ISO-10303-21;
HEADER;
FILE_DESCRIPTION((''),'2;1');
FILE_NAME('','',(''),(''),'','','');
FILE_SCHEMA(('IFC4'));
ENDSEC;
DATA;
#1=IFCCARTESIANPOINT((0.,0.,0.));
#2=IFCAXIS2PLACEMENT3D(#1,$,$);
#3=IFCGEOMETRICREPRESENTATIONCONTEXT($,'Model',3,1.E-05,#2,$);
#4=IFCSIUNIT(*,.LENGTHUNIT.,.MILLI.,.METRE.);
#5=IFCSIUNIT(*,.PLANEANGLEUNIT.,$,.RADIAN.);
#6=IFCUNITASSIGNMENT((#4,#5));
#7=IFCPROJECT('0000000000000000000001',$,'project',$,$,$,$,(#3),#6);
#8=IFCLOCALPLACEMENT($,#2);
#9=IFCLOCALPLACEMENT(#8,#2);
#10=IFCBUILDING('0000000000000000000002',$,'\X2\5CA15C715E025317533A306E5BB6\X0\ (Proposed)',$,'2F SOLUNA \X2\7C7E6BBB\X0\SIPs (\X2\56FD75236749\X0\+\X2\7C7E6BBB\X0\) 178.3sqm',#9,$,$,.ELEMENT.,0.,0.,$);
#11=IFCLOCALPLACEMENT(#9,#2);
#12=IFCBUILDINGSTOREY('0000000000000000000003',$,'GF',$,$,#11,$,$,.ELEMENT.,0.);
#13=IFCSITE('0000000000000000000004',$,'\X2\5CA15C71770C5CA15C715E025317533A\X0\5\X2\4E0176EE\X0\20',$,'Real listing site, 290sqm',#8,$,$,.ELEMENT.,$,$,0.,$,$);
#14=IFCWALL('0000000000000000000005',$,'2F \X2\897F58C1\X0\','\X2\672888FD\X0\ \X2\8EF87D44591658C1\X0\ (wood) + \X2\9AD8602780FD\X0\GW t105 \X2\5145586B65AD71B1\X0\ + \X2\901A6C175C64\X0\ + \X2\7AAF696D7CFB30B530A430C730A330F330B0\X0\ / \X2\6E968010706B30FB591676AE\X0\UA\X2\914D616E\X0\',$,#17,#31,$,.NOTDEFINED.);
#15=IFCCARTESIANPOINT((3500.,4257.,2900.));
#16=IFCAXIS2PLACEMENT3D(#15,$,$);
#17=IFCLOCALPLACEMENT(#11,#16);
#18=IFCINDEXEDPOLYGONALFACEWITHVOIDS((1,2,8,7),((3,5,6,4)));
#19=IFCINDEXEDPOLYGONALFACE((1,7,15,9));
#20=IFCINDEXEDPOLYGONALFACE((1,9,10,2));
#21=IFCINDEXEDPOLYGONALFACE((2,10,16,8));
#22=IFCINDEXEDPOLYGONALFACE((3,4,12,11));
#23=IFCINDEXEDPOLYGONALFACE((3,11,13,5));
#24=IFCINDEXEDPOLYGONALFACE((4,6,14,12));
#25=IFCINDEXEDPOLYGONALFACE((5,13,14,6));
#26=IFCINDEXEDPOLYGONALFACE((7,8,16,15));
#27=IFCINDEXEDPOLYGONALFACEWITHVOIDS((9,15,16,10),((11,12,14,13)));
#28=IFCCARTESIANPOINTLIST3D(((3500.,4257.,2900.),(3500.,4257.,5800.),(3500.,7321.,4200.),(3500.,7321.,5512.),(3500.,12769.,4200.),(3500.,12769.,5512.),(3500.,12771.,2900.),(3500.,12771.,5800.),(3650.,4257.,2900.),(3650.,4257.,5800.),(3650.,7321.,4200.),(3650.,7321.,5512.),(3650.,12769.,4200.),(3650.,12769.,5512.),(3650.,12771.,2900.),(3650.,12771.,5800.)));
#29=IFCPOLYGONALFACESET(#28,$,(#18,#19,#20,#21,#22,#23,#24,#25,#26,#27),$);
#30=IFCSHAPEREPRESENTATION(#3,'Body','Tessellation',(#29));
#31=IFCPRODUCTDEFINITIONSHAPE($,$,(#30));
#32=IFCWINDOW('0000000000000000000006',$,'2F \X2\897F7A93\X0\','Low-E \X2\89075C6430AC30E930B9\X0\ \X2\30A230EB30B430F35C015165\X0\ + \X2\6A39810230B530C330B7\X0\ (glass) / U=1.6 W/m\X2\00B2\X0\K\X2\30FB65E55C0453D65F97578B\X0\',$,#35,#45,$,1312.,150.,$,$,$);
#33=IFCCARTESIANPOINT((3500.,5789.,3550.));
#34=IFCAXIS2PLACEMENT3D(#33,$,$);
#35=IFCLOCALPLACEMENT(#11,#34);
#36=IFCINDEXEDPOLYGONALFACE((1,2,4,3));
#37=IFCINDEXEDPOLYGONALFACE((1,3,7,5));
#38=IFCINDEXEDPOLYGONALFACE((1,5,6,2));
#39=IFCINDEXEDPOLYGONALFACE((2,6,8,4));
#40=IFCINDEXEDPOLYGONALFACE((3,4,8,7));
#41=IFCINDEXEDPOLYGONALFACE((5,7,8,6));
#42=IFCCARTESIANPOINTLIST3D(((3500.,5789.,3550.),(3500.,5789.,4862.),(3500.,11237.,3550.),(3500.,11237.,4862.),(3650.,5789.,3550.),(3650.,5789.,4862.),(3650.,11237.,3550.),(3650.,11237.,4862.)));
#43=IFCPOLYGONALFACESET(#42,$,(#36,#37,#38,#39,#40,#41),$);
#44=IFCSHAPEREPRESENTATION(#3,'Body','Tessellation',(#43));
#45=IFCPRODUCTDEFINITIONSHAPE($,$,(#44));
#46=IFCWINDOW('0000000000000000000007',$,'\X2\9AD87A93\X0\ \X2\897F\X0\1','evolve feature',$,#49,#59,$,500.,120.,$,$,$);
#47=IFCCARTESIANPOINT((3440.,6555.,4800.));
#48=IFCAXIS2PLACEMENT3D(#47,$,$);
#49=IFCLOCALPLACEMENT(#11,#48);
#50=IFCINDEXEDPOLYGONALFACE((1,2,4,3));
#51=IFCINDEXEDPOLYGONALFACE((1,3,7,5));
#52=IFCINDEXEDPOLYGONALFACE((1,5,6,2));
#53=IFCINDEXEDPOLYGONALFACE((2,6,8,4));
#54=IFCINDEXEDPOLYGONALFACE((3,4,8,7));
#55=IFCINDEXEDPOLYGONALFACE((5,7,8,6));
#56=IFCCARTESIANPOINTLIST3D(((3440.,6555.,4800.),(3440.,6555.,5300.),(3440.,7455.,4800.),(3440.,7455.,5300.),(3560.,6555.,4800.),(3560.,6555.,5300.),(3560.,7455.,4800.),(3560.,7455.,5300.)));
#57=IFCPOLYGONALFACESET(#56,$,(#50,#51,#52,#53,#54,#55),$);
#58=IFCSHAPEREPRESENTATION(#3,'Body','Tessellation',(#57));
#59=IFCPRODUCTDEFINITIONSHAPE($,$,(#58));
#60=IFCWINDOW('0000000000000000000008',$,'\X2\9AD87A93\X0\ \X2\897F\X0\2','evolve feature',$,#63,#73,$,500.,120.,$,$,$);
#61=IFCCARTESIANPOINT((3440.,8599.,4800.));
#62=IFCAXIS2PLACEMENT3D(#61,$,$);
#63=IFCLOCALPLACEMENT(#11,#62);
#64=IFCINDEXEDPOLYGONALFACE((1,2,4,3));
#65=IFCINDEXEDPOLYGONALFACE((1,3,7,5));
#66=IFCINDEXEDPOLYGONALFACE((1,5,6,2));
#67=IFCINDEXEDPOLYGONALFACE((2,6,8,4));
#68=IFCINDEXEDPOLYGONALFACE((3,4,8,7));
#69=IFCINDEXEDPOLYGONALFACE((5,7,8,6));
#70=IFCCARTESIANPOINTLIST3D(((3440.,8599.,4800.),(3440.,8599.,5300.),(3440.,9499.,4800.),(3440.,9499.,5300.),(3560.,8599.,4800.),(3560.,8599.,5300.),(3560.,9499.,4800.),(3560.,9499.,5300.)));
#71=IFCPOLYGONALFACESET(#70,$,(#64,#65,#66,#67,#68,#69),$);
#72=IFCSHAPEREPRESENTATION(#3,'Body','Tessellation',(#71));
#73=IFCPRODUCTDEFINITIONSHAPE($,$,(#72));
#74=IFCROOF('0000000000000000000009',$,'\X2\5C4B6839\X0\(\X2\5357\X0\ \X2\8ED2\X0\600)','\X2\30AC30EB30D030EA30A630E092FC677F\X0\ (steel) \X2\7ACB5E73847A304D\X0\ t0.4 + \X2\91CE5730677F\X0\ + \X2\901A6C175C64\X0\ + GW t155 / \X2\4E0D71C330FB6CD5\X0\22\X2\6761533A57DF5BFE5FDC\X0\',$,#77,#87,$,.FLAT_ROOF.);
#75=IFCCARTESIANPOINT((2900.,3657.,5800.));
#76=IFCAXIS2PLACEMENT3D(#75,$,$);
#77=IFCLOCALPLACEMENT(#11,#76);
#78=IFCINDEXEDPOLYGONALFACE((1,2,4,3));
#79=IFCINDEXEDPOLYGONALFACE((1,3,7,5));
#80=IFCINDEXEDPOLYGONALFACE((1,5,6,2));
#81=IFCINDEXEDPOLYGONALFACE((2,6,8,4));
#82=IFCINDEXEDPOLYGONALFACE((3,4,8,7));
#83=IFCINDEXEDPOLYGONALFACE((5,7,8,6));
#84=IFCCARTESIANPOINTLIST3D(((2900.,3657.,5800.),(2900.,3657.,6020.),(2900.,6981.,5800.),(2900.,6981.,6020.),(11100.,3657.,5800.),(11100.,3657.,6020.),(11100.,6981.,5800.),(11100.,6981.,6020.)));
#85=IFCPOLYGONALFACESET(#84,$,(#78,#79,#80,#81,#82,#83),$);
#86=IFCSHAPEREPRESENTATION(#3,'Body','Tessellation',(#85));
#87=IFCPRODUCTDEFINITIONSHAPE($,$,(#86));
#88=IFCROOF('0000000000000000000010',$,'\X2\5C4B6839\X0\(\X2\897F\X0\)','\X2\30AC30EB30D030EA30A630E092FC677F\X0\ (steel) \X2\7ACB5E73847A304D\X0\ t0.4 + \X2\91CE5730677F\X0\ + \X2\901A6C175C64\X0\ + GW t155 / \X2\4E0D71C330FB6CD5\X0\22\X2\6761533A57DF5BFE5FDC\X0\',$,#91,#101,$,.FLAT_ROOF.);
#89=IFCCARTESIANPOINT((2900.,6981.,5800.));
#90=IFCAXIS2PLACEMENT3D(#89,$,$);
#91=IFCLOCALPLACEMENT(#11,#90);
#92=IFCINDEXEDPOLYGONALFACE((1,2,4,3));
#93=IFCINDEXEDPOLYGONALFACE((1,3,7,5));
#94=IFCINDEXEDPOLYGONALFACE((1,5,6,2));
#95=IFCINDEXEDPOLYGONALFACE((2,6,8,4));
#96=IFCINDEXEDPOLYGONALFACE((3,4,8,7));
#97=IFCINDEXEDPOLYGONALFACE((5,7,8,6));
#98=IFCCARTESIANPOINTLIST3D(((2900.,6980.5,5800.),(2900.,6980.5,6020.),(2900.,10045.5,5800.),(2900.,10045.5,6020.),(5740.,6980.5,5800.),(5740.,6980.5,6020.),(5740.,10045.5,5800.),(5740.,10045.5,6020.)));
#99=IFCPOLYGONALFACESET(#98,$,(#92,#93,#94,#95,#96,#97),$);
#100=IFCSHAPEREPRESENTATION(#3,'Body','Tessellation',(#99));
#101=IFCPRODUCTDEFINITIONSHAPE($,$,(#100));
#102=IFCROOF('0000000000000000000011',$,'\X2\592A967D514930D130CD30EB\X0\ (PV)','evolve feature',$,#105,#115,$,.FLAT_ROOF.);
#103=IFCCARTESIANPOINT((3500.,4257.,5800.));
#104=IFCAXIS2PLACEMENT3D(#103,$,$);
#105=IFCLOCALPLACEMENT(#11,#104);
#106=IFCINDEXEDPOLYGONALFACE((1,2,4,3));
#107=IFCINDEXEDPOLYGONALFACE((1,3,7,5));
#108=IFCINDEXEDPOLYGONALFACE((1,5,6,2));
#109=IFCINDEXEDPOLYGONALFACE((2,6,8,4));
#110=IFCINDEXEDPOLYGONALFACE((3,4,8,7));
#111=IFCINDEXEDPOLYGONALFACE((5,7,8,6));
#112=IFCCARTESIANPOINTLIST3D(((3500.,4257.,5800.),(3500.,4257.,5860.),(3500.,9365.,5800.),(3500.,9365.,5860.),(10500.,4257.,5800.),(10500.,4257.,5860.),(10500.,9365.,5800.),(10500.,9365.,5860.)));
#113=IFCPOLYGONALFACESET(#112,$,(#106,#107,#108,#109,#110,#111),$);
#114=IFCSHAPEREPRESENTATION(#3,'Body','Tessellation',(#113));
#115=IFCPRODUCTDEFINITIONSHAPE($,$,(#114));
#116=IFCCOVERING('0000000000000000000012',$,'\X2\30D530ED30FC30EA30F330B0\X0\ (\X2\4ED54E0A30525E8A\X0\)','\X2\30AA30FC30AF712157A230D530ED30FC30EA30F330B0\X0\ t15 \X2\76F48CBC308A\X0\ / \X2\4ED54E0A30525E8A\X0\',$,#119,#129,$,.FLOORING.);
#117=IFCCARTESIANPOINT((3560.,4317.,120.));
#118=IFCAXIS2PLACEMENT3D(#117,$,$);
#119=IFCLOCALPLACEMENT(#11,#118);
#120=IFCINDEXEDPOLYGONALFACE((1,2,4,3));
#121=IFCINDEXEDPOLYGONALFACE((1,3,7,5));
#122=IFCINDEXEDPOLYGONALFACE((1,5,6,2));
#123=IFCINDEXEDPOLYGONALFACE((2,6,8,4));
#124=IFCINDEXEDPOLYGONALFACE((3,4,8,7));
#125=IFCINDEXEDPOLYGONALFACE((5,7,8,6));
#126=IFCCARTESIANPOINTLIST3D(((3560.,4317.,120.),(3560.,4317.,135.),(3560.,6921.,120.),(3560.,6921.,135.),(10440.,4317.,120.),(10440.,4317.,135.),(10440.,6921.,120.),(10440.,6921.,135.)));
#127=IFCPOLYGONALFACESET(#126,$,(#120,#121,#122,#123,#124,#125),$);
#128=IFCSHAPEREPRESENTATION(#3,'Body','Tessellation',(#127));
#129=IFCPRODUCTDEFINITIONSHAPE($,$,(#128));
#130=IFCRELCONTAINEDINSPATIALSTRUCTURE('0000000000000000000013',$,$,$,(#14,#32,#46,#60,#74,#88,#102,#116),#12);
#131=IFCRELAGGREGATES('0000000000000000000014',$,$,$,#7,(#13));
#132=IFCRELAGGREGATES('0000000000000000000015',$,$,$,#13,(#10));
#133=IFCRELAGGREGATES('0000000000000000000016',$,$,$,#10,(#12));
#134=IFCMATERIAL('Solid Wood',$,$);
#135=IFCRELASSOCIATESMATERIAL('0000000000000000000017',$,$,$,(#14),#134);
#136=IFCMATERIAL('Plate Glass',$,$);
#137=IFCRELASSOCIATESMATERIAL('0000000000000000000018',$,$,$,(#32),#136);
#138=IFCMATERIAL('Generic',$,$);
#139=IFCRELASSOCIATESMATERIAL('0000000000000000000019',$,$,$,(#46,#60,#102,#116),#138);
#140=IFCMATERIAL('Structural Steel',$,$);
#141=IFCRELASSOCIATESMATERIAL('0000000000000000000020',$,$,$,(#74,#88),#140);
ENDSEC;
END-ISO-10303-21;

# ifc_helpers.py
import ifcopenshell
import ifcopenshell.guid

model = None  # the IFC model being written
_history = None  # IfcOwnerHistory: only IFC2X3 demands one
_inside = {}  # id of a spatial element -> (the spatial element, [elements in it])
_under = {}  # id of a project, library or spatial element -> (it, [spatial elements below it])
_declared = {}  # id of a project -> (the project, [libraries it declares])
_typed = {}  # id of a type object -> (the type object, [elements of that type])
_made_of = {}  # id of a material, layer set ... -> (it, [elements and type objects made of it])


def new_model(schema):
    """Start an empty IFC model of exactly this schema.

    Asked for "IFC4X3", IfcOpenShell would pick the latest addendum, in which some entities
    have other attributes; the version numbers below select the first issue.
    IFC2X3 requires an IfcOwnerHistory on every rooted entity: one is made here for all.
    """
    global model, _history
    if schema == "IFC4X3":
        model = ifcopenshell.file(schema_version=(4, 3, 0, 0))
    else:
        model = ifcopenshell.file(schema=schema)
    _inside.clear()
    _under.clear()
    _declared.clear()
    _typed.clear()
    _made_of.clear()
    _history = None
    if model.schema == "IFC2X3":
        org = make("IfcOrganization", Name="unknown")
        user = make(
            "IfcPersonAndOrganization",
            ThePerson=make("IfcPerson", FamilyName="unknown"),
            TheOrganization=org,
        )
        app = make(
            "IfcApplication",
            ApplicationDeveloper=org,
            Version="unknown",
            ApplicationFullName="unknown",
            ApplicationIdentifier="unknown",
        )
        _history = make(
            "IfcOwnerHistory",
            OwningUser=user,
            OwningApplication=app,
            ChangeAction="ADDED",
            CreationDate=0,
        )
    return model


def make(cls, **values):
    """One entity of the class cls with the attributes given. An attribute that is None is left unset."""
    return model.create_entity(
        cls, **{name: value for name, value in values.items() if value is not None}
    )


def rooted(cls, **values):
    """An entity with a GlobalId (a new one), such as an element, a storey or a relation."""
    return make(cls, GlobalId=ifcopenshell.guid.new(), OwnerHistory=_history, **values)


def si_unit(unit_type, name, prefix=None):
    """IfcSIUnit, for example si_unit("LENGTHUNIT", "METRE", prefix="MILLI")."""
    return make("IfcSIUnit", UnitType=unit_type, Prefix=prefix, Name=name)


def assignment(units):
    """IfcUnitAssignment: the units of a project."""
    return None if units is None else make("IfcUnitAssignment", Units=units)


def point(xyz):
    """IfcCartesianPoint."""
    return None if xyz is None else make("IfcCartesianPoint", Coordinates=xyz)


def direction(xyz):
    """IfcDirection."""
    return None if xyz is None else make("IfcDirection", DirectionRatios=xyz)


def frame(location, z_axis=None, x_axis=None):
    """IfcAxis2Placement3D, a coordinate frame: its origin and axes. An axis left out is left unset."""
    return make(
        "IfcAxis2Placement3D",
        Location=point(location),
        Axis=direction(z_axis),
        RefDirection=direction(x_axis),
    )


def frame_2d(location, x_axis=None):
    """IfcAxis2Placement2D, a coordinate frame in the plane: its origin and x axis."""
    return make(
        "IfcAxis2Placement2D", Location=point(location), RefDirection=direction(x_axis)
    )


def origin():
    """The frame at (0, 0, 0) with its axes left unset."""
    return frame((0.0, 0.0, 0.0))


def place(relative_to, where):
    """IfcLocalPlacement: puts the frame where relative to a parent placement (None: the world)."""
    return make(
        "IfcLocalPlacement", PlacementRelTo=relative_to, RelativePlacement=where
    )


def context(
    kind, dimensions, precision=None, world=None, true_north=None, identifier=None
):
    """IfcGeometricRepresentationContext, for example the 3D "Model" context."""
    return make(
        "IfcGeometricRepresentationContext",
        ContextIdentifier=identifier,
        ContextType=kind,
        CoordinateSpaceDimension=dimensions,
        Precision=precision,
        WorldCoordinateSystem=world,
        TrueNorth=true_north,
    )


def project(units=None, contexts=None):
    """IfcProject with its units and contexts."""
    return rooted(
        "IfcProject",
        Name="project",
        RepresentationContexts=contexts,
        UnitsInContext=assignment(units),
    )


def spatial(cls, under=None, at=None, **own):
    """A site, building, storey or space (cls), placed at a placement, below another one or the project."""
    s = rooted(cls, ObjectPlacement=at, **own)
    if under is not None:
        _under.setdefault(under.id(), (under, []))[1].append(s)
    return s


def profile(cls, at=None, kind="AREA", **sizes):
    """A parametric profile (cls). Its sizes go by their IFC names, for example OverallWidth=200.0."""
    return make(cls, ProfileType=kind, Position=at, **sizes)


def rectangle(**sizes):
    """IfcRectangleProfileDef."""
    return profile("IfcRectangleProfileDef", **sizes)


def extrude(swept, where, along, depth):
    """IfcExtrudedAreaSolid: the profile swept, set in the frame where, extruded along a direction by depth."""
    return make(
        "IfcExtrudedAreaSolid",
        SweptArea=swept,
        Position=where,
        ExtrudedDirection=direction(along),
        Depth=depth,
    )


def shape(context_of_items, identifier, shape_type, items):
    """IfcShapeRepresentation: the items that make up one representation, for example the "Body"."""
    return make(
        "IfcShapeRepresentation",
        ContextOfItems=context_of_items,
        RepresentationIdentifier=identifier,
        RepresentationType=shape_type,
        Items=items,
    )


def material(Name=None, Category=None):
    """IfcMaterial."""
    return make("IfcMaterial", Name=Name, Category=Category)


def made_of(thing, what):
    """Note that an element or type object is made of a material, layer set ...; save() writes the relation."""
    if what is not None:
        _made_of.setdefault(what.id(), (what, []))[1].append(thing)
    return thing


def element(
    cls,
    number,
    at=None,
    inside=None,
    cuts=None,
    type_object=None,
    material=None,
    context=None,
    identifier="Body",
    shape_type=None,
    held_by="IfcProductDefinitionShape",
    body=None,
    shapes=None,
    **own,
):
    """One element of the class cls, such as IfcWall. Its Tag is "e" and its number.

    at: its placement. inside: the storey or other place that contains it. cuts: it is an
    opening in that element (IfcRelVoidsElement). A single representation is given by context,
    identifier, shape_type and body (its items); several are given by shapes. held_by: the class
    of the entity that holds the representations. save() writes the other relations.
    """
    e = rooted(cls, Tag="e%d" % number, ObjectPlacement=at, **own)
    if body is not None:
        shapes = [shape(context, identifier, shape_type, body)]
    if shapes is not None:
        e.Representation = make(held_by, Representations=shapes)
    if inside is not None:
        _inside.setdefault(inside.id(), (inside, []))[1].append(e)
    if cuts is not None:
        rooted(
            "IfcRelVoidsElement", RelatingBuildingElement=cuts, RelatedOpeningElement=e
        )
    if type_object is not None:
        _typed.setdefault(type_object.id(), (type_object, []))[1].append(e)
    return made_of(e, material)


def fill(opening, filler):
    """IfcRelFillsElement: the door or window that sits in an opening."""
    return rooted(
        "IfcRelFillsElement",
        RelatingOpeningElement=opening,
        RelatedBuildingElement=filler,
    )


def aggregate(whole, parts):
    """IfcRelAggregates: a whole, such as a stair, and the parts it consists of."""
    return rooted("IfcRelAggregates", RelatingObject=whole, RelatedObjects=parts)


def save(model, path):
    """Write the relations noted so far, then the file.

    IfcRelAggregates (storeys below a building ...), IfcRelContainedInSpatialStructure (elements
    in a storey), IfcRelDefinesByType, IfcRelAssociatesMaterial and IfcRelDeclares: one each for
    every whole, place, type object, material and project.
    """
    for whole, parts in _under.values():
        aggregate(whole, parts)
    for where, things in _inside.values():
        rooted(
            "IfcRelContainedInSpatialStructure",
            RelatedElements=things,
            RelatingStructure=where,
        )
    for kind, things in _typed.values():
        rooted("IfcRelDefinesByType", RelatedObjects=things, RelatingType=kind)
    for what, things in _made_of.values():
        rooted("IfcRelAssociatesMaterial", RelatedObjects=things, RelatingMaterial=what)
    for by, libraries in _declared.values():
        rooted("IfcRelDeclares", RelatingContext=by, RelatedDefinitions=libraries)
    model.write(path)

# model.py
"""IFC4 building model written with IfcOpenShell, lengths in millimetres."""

from ifc_helpers import new_model, si_unit, frame, frame_2d, origin, place, context, project, spatial, rectangle, extrude, material, element, fill, save


model = new_model("IFC4")

# Units and contexts
model_context = context("Model", 3, precision=1e-05, world=origin())
ifc_project = project(units=[si_unit("LENGTHUNIT", "METRE", prefix="MILLI"), si_unit("PLANEANGLEUNIT", "RADIAN")], contexts=[model_context])

# Site, building, storey
site_placement = place(None, origin())
site = spatial("IfcSite", under=ifc_project, at=site_placement, Name="岡山県岡山市北区5丁目20", ObjectType="Real listing site, 290sqm", CompositionType="ELEMENT", RefElevation=0.0)
building_placement = place(site_placement, origin())
building = spatial("IfcBuilding", under=site, at=building_placement, Name="岡山市北区の家 (Proposed)", ObjectType="2F SOLUNA 籾殻SIPs (国産杉+籾殻) 178.3sqm", CompositionType="ELEMENT", ElevationOfRefHeight=0.0, ElevationOfTerrain=0.0)
storey_placement = place(building_placement, origin())
storey = spatial("IfcBuildingStorey", under=building, at=storey_placement, Name="GF", CompositionType="ELEMENT", Elevation=0.0)

# Shared definitions
ifc_material_1 = material(Name="Solid Wood")
ifc_material_2 = material(Name="Generic")

# Shared definitions
ifc_material_3 = material(Name="Plate Glass")

# Wall, openings, windows
wall_1_placement = place(storey_placement, frame((3500.0, 4257.0, 2900.0)))
wall_1 = element("IfcWall", 1, at=wall_1_placement, inside=storey, material=ifc_material_1, Name="2F 西壁", Description="木製 軸組外壁 (wood) + 高性能GW t105 充填断熱 + 通気層 + 窯業系サイディング / 準耐火・外皮UA配慮", PredefinedType="NOTDEFINED", context=model_context, shape_type="SweptSolid", body=[
    extrude(rectangle(XDim=150.0, YDim=8514.0, at=frame_2d((75.0, 4257.0))), frame((3500.0, 4257.0, 2900.0)), (0.0, 0.0, 1.0), 2900.0),
])
opening_1_placement = place(storey_placement, frame((3500.0, 5789.0, 3550.0)))
opening_1 = element("IfcOpeningElement", 2, at=opening_1_placement, cuts=wall_1, PredefinedType="NOTDEFINED", context=model_context, shape_type="SweptSolid", body=[
    extrude(rectangle(XDim=150.0, YDim=5448.0, at=frame_2d((75.0, 2724.0))), frame((3500.0, 5789.0, 3550.0)), (0.0, 0.0, 1.0), 1312.0),
])
opening_2_placement = place(storey_placement, frame((3440.0, 6555.0, 4800.0)))
opening_2 = element("IfcOpeningElement", 3, at=opening_2_placement, cuts=wall_1, PredefinedType="NOTDEFINED", context=model_context, shape_type="SweptSolid", body=[
    extrude(rectangle(XDim=120.0, YDim=900.0, at=frame_2d((60.0, 450.0))), frame((3440.0, 6555.0, 4800.0)), (0.0, 0.0, 1.0), 500.0),
])
opening_3_placement = place(storey_placement, frame((3440.0, 8599.0, 4800.0)))
opening_3 = element("IfcOpeningElement", 4, at=opening_3_placement, cuts=wall_1, PredefinedType="NOTDEFINED", context=model_context, shape_type="SweptSolid", body=[
    extrude(rectangle(XDim=120.0, YDim=900.0, at=frame_2d((60.0, 450.0))), frame((3440.0, 8599.0, 4800.0)), (0.0, 0.0, 1.0), 500.0),
])
window_1_placement = place(storey_placement, frame((3500.0, 5789.0, 3550.0)))
window_1 = element("IfcWindow", 5, at=window_1_placement, inside=storey, material=ifc_material_3, Name="2F 西窓", Description="Low-E 複層ガラス アルゴン封入 + 樹脂サッシ (glass) / U=1.6 W/m²K・日射取得型", OverallHeight=1312.0, OverallWidth=150.0, context=model_context, shape_type="SweptSolid", body=[
    extrude(rectangle(XDim=150.0, YDim=5448.0, at=frame_2d((75.0, 2724.0))), frame((3500.0, 5789.0, 3550.0)), (0.0, 0.0, 1.0), 1312.0),
])
fill(opening_1, window_1)
window_2_placement = place(storey_placement, frame((3440.0, 6555.0, 4800.0)))
window_2 = element("IfcWindow", 6, at=window_2_placement, inside=storey, material=ifc_material_2, Name="高窓 西1", Description="evolve feature", OverallHeight=500.0, OverallWidth=120.0, context=model_context, shape_type="SweptSolid", body=[
    extrude(rectangle(XDim=120.0, YDim=900.0, at=frame_2d((60.0, 450.0))), frame((3440.0, 6555.0, 4800.0)), (0.0, 0.0, 1.0), 500.0),
])
fill(opening_2, window_2)
window_3_placement = place(storey_placement, frame((3440.0, 8599.0, 4800.0)))
window_3 = element("IfcWindow", 7, at=window_3_placement, inside=storey, material=ifc_material_2, Name="高窓 西2", Description="evolve feature", OverallHeight=500.0, OverallWidth=120.0, context=model_context, shape_type="SweptSolid", body=[
    extrude(rectangle(XDim=120.0, YDim=900.0, at=frame_2d((60.0, 450.0))), frame((3440.0, 8599.0, 4800.0)), (0.0, 0.0, 1.0), 500.0),
])
fill(opening_3, window_3)

# Roofs
ifc_material_4 = material(Name="Structural Steel")
roof_1_placement = place(storey_placement, frame((2900.0, 3657.0, 5800.0)))
element("IfcRoof", 8, at=roof_1_placement, inside=storey, material=ifc_material_4, Name="屋根(南 軒600)", Description="ガルバリウム鋼板 (steel) 立平葺き t0.4 + 野地板 + 通気層 + GW t155 / 不燃・法22条区域対応", PredefinedType="FLAT_ROOF", context=model_context, shape_type="SweptSolid", body=[
    extrude(rectangle(XDim=8200.0, YDim=3324.0, at=frame_2d((4100.0, 1662.0))), frame((2900.0, 3657.0, 5800.0)), (0.0, 0.0, 1.0), 220.0),
])
roof_2_placement = place(storey_placement, frame((2900.0, 6981.0, 5800.0)))
element("IfcRoof", 9, at=roof_2_placement, inside=storey, material=ifc_material_4, Name="屋根(西)", Description="ガルバリウム鋼板 (steel) 立平葺き t0.4 + 野地板 + 通気層 + GW t155 / 不燃・法22条区域対応", PredefinedType="FLAT_ROOF", context=model_context, shape_type="SweptSolid", body=[
    extrude(rectangle(XDim=2840.0, YDim=3065.0, at=frame_2d((1420.0, 1532.0))), frame((2900.0, 6981.0, 5800.0)), (0.0, 0.0, 1.0), 220.0),
])
roof_3_placement = place(storey_placement, frame((3500.0, 4257.0, 5800.0)))
element("IfcRoof", 10, at=roof_3_placement, inside=storey, material=ifc_material_2, Name="太陽光パネル (PV)", Description="evolve feature", PredefinedType="FLAT_ROOF", context=model_context, shape_type="SweptSolid", body=[
    extrude(rectangle(XDim=7000.0, YDim=5108.0, at=frame_2d((3500.0, 2554.0))), frame((3500.0, 4257.0, 5800.0)), (0.0, 0.0, 1.0), 60.0),
])

# Covering
covering_placement = place(storey_placement, frame((3560.0, 4317.0, 120.0)))
element("IfcCovering", 11, at=covering_placement, inside=storey, material=ifc_material_2, Name="フローリング (仕上げ床)", Description="オーク無垢フローリング t15 直貼り / 仕上げ床", PredefinedType="FLOORING", context=model_context, shape_type="SweptSolid", body=[
    extrude(rectangle(XDim=6880.0, YDim=2604.0, at=frame_2d((3440.0, 1302.0))), frame((3560.0, 4317.0, 120.0)), (0.0, 0.0, 1.0), 15.0),
])

save(model, "model.ifc")
